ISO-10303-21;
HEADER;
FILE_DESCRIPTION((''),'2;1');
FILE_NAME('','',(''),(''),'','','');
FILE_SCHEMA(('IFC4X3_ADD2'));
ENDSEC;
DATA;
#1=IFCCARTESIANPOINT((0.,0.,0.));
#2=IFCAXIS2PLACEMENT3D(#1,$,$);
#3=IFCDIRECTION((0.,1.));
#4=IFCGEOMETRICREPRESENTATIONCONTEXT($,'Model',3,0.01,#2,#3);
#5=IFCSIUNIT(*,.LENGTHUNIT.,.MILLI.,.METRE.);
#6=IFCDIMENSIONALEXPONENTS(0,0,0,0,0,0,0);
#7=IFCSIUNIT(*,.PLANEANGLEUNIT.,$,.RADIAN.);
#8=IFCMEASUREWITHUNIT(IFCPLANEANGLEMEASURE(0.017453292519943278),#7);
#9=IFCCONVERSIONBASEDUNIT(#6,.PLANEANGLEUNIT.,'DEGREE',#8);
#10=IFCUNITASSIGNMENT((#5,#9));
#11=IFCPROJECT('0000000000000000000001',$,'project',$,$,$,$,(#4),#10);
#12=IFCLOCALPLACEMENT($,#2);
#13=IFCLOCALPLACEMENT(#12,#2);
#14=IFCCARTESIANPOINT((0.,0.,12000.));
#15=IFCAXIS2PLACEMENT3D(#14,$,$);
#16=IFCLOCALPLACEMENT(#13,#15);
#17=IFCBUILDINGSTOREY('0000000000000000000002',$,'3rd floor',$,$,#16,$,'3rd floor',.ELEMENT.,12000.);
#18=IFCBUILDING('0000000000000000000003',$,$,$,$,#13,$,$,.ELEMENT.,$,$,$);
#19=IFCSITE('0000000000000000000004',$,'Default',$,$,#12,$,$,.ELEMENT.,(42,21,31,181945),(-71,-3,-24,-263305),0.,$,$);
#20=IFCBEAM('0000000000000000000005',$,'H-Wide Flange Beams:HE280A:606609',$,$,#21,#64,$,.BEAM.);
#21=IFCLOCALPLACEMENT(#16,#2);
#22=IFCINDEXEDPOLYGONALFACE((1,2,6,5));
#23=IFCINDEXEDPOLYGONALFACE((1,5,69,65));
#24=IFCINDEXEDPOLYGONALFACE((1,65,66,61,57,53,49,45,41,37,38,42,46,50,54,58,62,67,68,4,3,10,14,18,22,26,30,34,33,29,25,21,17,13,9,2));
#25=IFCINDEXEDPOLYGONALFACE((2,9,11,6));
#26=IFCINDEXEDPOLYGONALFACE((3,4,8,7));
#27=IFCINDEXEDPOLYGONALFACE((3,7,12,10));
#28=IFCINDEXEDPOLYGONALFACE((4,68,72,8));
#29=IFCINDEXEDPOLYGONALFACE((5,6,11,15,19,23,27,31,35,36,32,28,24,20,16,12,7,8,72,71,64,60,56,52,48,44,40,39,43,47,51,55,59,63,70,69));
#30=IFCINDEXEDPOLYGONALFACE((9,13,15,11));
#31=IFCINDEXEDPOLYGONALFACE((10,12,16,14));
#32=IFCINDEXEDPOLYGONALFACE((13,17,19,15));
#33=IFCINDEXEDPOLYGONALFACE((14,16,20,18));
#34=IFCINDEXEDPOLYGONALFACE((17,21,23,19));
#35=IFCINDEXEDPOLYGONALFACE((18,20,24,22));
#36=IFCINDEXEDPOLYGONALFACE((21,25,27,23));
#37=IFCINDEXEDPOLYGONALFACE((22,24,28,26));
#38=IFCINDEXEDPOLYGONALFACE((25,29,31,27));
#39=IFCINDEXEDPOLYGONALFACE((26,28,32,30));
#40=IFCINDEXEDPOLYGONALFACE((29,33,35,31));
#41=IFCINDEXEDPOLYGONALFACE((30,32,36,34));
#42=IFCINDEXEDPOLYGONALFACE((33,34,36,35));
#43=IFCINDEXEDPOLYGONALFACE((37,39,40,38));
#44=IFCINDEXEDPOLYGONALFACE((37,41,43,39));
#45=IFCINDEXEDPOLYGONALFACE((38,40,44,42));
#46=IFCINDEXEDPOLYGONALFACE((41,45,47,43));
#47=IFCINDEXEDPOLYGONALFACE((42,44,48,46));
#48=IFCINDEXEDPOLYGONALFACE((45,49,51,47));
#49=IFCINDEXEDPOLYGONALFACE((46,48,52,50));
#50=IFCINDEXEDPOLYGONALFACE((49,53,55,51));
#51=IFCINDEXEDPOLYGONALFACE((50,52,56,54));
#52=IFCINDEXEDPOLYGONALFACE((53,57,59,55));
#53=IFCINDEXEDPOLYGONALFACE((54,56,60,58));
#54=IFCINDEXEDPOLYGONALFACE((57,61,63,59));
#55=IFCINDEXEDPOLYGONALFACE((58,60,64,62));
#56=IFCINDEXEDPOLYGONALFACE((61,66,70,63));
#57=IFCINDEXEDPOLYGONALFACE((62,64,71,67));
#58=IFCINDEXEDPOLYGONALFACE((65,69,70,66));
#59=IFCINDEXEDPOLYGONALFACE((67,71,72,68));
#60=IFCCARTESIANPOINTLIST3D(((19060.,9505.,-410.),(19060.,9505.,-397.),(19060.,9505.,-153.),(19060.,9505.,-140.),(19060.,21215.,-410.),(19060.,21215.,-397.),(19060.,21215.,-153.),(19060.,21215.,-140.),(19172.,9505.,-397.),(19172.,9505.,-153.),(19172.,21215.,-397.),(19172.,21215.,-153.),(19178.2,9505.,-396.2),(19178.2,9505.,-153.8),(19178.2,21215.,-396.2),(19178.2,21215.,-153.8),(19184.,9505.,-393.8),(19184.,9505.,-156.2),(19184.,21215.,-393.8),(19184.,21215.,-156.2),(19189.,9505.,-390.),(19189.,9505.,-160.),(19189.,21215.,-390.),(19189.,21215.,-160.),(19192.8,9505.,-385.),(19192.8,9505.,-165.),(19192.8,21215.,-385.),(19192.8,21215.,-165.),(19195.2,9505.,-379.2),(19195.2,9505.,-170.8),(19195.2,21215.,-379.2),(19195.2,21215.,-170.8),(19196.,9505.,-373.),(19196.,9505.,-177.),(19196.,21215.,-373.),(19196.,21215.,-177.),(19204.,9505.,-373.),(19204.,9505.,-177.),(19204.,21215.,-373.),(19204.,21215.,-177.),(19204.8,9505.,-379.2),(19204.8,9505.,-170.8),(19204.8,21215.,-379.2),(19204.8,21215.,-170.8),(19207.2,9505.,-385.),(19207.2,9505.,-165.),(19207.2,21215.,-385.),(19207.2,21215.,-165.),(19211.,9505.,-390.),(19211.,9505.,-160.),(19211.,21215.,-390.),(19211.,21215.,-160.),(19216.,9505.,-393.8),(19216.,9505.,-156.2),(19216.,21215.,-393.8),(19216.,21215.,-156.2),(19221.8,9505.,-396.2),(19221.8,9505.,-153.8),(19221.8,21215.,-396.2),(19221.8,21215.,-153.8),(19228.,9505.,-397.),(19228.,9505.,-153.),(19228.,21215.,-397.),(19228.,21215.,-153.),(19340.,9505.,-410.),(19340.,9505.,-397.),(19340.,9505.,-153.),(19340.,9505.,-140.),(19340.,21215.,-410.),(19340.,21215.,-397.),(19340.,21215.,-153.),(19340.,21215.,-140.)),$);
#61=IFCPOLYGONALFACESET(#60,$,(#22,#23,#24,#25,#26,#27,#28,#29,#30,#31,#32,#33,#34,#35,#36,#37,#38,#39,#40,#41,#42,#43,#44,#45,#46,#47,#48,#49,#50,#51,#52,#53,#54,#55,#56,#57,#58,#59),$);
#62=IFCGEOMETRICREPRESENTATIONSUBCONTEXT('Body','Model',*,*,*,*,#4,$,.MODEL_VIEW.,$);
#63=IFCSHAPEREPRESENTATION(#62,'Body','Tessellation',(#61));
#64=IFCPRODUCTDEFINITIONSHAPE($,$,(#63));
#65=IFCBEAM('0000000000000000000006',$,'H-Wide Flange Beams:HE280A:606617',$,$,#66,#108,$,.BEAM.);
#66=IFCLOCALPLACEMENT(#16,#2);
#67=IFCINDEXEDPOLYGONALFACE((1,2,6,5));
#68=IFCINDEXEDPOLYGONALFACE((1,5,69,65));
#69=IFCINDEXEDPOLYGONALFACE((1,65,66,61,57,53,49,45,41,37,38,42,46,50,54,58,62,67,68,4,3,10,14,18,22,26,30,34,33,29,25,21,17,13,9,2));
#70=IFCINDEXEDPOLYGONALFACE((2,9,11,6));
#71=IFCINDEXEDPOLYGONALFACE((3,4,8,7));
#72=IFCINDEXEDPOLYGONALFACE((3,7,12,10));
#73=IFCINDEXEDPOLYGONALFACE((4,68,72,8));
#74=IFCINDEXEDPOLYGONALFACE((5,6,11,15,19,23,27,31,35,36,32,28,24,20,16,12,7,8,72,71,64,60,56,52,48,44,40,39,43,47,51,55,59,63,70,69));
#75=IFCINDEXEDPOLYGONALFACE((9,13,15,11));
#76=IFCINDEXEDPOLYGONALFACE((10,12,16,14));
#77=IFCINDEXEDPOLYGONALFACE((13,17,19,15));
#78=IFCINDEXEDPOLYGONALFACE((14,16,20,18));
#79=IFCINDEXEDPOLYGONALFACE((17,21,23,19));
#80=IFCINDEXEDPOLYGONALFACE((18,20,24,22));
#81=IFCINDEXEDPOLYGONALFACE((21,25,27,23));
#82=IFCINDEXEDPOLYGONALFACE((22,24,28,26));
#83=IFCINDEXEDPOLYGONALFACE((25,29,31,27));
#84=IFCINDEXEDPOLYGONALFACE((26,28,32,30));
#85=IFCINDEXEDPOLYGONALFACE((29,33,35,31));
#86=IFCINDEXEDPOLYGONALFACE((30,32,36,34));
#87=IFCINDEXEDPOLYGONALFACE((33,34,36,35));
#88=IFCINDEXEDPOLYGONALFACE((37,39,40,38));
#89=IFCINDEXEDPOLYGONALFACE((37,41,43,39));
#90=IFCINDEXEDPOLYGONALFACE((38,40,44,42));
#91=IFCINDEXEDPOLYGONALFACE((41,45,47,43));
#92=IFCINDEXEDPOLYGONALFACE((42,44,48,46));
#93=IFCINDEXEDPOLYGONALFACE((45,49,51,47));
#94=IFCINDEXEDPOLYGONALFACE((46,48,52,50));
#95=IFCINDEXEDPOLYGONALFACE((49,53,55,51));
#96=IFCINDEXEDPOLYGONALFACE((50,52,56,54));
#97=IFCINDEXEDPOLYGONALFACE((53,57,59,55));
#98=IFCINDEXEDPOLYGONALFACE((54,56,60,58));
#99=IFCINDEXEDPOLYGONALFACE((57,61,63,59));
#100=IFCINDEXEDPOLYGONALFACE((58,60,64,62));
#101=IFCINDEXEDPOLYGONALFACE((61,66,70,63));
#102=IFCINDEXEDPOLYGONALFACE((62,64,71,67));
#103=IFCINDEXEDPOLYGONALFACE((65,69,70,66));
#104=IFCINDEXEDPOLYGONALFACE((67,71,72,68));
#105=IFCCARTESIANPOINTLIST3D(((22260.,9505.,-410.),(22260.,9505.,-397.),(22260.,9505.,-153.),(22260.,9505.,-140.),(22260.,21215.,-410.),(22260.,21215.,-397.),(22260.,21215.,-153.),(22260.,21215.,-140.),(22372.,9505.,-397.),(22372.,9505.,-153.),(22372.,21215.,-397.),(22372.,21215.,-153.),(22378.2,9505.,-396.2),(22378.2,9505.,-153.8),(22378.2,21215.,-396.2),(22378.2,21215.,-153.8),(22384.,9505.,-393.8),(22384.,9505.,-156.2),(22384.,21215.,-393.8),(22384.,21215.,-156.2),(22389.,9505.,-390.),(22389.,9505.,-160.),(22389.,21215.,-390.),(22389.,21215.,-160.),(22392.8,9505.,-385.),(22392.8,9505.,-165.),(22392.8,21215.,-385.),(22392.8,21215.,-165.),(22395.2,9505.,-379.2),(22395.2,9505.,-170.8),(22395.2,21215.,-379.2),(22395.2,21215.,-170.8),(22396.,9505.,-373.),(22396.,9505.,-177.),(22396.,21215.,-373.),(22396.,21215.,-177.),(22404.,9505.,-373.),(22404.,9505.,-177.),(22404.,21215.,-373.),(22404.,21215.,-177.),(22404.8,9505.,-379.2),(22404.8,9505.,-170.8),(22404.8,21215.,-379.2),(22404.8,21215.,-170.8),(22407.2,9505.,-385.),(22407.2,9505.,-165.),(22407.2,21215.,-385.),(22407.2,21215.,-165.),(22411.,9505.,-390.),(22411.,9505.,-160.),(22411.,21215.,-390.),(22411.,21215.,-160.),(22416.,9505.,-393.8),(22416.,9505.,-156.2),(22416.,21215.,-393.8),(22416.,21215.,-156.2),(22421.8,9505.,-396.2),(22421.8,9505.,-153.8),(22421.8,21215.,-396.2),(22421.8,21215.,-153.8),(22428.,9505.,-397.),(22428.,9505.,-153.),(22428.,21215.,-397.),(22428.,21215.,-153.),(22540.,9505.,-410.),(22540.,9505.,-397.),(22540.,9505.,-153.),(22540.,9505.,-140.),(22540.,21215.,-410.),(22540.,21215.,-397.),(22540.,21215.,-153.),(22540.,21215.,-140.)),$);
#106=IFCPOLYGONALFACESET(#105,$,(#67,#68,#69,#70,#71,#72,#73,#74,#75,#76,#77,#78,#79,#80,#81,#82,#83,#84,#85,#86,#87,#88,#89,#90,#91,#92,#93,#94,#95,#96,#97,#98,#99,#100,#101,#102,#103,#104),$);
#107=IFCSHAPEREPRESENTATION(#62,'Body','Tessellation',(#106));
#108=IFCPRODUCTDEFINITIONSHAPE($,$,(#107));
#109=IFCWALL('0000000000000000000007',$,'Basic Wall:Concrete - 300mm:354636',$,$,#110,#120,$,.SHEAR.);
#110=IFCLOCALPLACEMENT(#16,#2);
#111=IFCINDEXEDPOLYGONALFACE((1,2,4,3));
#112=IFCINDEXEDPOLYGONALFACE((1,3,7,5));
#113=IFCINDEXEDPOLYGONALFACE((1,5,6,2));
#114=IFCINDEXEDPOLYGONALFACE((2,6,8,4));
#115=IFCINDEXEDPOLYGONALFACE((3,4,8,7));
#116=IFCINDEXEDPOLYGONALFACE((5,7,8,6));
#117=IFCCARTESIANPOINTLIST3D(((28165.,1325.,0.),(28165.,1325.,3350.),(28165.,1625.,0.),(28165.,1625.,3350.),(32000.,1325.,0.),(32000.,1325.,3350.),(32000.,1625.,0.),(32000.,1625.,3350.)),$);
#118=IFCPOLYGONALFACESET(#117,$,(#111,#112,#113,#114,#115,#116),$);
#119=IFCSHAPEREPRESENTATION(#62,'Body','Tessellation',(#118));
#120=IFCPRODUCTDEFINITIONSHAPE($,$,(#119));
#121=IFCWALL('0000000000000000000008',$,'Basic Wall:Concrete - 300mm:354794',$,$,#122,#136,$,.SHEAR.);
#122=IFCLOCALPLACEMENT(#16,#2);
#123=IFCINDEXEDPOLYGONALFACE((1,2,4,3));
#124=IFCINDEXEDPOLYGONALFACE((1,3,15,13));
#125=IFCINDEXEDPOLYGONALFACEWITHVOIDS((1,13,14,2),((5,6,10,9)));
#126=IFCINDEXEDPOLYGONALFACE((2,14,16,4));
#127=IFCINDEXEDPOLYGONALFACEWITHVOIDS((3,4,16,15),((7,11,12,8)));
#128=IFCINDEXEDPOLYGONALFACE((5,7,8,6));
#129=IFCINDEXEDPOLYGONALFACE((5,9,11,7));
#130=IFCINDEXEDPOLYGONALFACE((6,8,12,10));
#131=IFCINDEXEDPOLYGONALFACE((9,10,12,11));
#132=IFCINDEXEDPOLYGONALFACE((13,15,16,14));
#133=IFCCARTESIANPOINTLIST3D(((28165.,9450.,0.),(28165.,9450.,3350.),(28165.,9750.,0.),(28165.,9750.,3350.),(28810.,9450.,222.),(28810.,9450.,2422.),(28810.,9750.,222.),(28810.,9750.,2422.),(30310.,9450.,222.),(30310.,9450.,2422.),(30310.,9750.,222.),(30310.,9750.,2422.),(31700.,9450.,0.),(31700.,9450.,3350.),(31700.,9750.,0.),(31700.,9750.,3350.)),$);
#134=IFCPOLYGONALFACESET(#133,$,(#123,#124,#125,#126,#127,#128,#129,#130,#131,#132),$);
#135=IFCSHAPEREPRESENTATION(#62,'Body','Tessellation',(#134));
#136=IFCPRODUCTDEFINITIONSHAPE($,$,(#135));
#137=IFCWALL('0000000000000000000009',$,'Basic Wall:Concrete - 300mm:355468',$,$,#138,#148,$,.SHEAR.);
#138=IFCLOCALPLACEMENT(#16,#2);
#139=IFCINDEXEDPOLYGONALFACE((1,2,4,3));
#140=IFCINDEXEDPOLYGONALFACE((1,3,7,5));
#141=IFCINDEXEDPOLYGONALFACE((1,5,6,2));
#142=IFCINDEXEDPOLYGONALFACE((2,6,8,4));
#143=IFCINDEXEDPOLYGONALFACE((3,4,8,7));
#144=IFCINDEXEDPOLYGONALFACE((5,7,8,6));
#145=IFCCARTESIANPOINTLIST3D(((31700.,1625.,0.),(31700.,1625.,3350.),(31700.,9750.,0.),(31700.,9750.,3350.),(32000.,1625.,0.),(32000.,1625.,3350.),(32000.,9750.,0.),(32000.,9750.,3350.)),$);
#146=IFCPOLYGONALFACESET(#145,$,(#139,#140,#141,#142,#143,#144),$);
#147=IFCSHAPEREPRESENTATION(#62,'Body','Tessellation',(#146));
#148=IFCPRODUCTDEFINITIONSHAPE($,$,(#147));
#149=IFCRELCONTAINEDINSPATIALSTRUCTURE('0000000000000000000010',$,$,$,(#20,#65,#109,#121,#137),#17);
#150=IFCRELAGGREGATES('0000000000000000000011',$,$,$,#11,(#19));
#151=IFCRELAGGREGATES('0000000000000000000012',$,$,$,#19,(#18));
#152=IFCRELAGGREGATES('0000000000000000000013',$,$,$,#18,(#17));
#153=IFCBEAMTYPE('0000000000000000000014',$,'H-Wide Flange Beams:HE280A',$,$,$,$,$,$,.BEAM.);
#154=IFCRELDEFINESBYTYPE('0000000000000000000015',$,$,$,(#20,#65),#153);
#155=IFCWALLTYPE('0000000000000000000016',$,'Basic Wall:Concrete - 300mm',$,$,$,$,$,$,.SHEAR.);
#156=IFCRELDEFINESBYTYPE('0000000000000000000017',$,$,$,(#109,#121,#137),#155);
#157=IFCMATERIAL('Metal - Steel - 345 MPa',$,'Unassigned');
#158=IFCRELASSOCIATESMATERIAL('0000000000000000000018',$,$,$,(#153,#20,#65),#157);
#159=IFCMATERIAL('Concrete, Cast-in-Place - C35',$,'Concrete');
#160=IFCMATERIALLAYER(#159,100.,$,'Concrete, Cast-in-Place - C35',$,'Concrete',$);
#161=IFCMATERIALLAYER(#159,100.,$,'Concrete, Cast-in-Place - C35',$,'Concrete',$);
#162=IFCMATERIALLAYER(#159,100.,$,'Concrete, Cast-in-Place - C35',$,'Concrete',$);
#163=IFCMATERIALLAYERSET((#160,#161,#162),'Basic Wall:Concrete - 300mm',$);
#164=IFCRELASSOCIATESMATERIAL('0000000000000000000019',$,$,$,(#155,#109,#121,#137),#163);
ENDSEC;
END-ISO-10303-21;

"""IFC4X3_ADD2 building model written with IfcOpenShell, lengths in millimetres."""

from ifc_helpers import new_model, entity, si_unit, converted_unit, direction, frame, frame_2d, origin, place, context, subcontext, project, spatial, polyline, circle_curve, parameter, trimmed, segment, composite_curve, rectangle, outline, extrude, source, transform, mapped, material, layer, layer_set, material_profile, profile_set, profile_usage, type_object, type_shapes, element, save


model = new_model("IFC4X3_ADD2")

# Units and contexts
model_context = context("Model", 3, precision=0.01, world=origin(), true_north=direction((0.0, 1.0)))
body_context = subcontext(model_context, "Body", "Model", "MODEL_VIEW")
ifc_project = project(units=[si_unit("LENGTHUNIT", "METRE", prefix="MILLI"), converted_unit("PLANEANGLEUNIT", "DEGREE", entity("IfcPlaneAngleMeasure", 0.017453292519943278), si_unit("PLANEANGLEUNIT", "RADIAN"), dimensions=[0, 0, 0, 0, 0, 0, 0])], contexts=[model_context])

# Site, building, storey
site_placement = place(None, origin())
site = spatial("IfcSite", under=ifc_project, at=site_placement, Name="Default", CompositionType="ELEMENT", RefLatitude=(42, 21, 31, 181945), RefLongitude=(-71, -3, -24, -263305), RefElevation=0.0)
building_placement = place(site_placement, origin())
building = spatial("IfcBuilding", under=site, at=building_placement, CompositionType="ELEMENT")
storey_placement = place(building_placement, frame((0.0, 0.0, 12000.0)))
storey = spatial("IfcBuildingStorey", under=building, at=storey_placement, Name="3rd floor", LongName="3rd floor", CompositionType="ELEMENT", Elevation=12000.0)

# Beams
ifc_material_1 = material(Name="Metal - Steel - 345 MPa", Category="Unassigned")
ifc_material_profile_1 = material_profile(ifc_material_1, outline(composite_curve([segment(polyline([(-140.0, -122.0), (-140.0, -135.0)]), True, "CONTINUOUS"), segment(polyline([(-140.0, -135.0), (140.0, -135.0)]), True, "CONTINUOUS"), segment(polyline([(140.0, -135.0), (140.0, -122.0)]), True, "CONTINUOUS"), segment(polyline([(140.0, -122.0), (28.0, -122.0)]), True, "CONTINUOUS"), segment(trimmed(circle_curve(frame_2d((28.0, -98.0), x_axis=(1.0, 0.0)), 24.0), [parameter(180.0)], [parameter(270.0)], True, "PARAMETER"), False, "CONTINUOUS"), segment(polyline([(4.0, -98.0), (4.0, 98.0)]), True, "CONTINUOUS"), segment(trimmed(circle_curve(frame_2d((28.0, 98.0), x_axis=(1.0, 0.0)), 24.0), [parameter(90.0)], [parameter(180.0)], True, "PARAMETER"), False, "CONTINUOUS"), segment(polyline([(28.0, 122.0), (140.0, 122.0)]), True, "CONTINUOUS"), segment(polyline([(140.0, 122.0), (140.0, 135.0)]), True, "CONTINUOUS"), segment(polyline([(140.0, 135.0), (-140.0, 135.0)]), True, "CONTINUOUS"), segment(polyline([(-140.0, 135.0), (-140.0, 122.0)]), True, "CONTINUOUS"), segment(polyline([(-140.0, 122.0), (-28.0, 122.0)]), True, "CONTINUOUS"), segment(trimmed(circle_curve(frame_2d((-28.0, 98.0), x_axis=(1.0, 0.0)), 24.0), [parameter(360.0)], [parameter(90.0)], True, "PARAMETER"), False, "CONTINUOUS"), segment(polyline([(-4.0, 98.0), (-4.0, -98.0)]), True, "CONTINUOUS"), segment(trimmed(circle_curve(frame_2d((-28.0, -98.0), x_axis=(1.0, 0.0)), 24.0), [parameter(270.0)], [parameter(360.0)], True, "PARAMETER"), False, "CONTINUOUS"), segment(polyline([(-28.0, -122.0), (-140.0, -122.0)]), True, "CONTINUOUS")], self_intersect=False)), Name="HE280A")
ifc_profile_set_1 = profile_set([ifc_material_profile_1], Name="HE280A")
ifc_profile_usage_1 = profile_usage(ifc_profile_set_1, cardinal=8)
beam_type_1 = type_object("IfcBeamType", Name="H-Wide Flange Beams:HE280A", PredefinedType="BEAM", material=ifc_profile_set_1)
shared_shape_1 = source(origin(), body_context, "Body", "SweptSolid", [
    extrude(outline(composite_curve([segment(polyline([(-140.0, -122.0), (-140.0, -135.0)]), True, "CONTINUOUS"), segment(polyline([(-140.0, -135.0), (140.0, -135.0)]), True, "CONTINUOUS"), segment(polyline([(140.0, -135.0), (140.0, -122.0)]), True, "CONTINUOUS"), segment(polyline([(140.0, -122.0), (28.0, -122.0)]), True, "CONTINUOUS"), segment(trimmed(circle_curve(frame_2d((28.0, -98.0), x_axis=(1.0, 0.0)), 24.0), [parameter(180.0)], [parameter(270.0)], True, "PARAMETER"), False, "CONTINUOUS"), segment(polyline([(4.0, -98.0), (4.0, 98.0)]), True, "CONTINUOUS"), segment(trimmed(circle_curve(frame_2d((28.0, 98.0), x_axis=(1.0, 0.0)), 24.0), [parameter(90.0)], [parameter(180.0)], True, "PARAMETER"), False, "CONTINUOUS"), segment(polyline([(28.0, 122.0), (140.0, 122.0)]), True, "CONTINUOUS"), segment(polyline([(140.0, 122.0), (140.0, 135.0)]), True, "CONTINUOUS"), segment(polyline([(140.0, 135.0), (-140.0, 135.0)]), True, "CONTINUOUS"), segment(polyline([(-140.0, 135.0), (-140.0, 122.0)]), True, "CONTINUOUS"), segment(polyline([(-140.0, 122.0), (-28.0, 122.0)]), True, "CONTINUOUS"), segment(trimmed(circle_curve(frame_2d((-28.0, 98.0), x_axis=(1.0, 0.0)), 24.0), [parameter(360.0)], [parameter(90.0)], True, "PARAMETER"), False, "CONTINUOUS"), segment(polyline([(-4.0, 98.0), (-4.0, -98.0)]), True, "CONTINUOUS"), segment(trimmed(circle_curve(frame_2d((-28.0, -98.0), x_axis=(1.0, 0.0)), 24.0), [parameter(270.0)], [parameter(360.0)], True, "PARAMETER"), False, "CONTINUOUS"), segment(polyline([(-28.0, -122.0), (-140.0, -122.0)]), True, "CONTINUOUS")], self_intersect=False)), frame((-4255.0, 0.0, 0.0), z_axis=(-1.0, 0.0, 0.0), x_axis=(0.0, -1.0, 0.0)), (0.0, 0.0, -1.0), 11710.0),
])
type_shapes(beam_type_1, [shared_shape_1])
for number, where, z_axis, x_axis, name in (
    (1, (19200.0, 16960.0, -275.0), (0.0, 0.0, 1.0), (0.0, -1.0, 0.0), "H-Wide Flange Beams:HE280A:606609"),
    (2, (22400.0, 16960.0, -275.0), (0.0, 0.0, 1.0), (0.0, -1.0, 0.0), "H-Wide Flange Beams:HE280A:606617"),
):
    element("IfcBeam", number, at=place(storey_placement, frame(where, z_axis=z_axis, x_axis=x_axis)), inside=storey, type_object=beam_type_1, material=ifc_profile_usage_1, Name=name, PredefinedType="BEAM", context=body_context, shape_type="MappedRepresentation", body=[
        mapped(shared_shape_1, transform((0.0, 0.0, 0.0), scale=1.0)),
    ])

# Wall
ifc_material_2 = material(Name="Concrete, Cast-in-Place - C35", Category="Concrete")
ifc_layer_1 = layer(ifc_material_2, 100.0, Name="Concrete, Cast-in-Place - C35", Category="Concrete")
ifc_layer_2 = layer(ifc_material_2, 100.0, Name="Concrete, Cast-in-Place - C35", Category="Concrete")
ifc_layer_3 = layer(ifc_material_2, 100.0, Name="Concrete, Cast-in-Place - C35", Category="Concrete")
ifc_layer_set_1 = layer_set([ifc_layer_1, ifc_layer_2, ifc_layer_3], Name="Basic Wall:Concrete - 300mm")
wall_type_1 = type_object("IfcWallType", Name="Basic Wall:Concrete - 300mm", PredefinedType="SHEAR", material=ifc_layer_set_1)
wall_1_placement = place(storey_placement, frame((32000.0, 1475.0, 0.0), z_axis=(0.0, 0.0, 1.0), x_axis=(-1.0, 0.0, 0.0)))
element("IfcWall", 3, at=wall_1_placement, inside=storey, type_object=wall_type_1, material=ifc_layer_set_1, Name="Basic Wall:Concrete - 300mm:354636", PredefinedType="SHEAR", context=body_context, shape_type="SweptSolid", body=[
    extrude(rectangle(XDim=3835.0, YDim=300.0, at=frame_2d((1917.5, 0.0), x_axis=(-1.0, 0.0))), origin(), (0.0, 0.0, 1.0), 3350.0),
])

# Wall, opening
wall_2_placement = place(storey_placement, frame((28165.0, 9600.0, 0.0)))
wall_2 = element("IfcWall", 4, at=wall_2_placement, inside=storey, type_object=wall_type_1, material=ifc_layer_set_1, Name="Basic Wall:Concrete - 300mm:354794", PredefinedType="SHEAR", context=body_context, shape_type="SweptSolid", body=[
    extrude(rectangle(XDim=3535.0, YDim=300.0, at=frame_2d((1767.5, 0.0), x_axis=(-1.0, 0.0))), origin(), (0.0, 0.0, 1.0), 3350.0),
])
opening_1_placement = place(wall_2_placement, frame((-28165.0, -9600.0, 222.0)))
element("IfcOpeningElement", 5, at=opening_1_placement, cuts=wall_2, PredefinedType="OPENING", context=body_context, shape_type="SweptSolid", body=[
    extrude(rectangle(XDim=2200.0, YDim=1500.0, at=frame_2d((0.0, 0.0), x_axis=(0.0, 1.0))), frame((29560.0, 9300.0, 1100.0), z_axis=(0.0, 1.0, 0.0), x_axis=(-1.0, 0.0, 0.0)), (0.0, 0.0, 1.0), 600.0),
])

# Wall
wall_3_placement = place(storey_placement, frame((31850.0, 9750.0, 0.0), z_axis=(0.0, 0.0, 1.0), x_axis=(0.0, -1.0, 0.0)))
element("IfcWall", 6, at=wall_3_placement, inside=storey, type_object=wall_type_1, material=ifc_layer_set_1, Name="Basic Wall:Concrete - 300mm:355468", PredefinedType="SHEAR", context=body_context, shape_type="SweptSolid", body=[
    extrude(rectangle(XDim=8125.0, YDim=300.0, at=frame_2d((4062.5, 0.0), x_axis=(-1.0, 0.0))), origin(), (0.0, 0.0, 1.0), 3350.0),
])

save(model, "model.ifc")
